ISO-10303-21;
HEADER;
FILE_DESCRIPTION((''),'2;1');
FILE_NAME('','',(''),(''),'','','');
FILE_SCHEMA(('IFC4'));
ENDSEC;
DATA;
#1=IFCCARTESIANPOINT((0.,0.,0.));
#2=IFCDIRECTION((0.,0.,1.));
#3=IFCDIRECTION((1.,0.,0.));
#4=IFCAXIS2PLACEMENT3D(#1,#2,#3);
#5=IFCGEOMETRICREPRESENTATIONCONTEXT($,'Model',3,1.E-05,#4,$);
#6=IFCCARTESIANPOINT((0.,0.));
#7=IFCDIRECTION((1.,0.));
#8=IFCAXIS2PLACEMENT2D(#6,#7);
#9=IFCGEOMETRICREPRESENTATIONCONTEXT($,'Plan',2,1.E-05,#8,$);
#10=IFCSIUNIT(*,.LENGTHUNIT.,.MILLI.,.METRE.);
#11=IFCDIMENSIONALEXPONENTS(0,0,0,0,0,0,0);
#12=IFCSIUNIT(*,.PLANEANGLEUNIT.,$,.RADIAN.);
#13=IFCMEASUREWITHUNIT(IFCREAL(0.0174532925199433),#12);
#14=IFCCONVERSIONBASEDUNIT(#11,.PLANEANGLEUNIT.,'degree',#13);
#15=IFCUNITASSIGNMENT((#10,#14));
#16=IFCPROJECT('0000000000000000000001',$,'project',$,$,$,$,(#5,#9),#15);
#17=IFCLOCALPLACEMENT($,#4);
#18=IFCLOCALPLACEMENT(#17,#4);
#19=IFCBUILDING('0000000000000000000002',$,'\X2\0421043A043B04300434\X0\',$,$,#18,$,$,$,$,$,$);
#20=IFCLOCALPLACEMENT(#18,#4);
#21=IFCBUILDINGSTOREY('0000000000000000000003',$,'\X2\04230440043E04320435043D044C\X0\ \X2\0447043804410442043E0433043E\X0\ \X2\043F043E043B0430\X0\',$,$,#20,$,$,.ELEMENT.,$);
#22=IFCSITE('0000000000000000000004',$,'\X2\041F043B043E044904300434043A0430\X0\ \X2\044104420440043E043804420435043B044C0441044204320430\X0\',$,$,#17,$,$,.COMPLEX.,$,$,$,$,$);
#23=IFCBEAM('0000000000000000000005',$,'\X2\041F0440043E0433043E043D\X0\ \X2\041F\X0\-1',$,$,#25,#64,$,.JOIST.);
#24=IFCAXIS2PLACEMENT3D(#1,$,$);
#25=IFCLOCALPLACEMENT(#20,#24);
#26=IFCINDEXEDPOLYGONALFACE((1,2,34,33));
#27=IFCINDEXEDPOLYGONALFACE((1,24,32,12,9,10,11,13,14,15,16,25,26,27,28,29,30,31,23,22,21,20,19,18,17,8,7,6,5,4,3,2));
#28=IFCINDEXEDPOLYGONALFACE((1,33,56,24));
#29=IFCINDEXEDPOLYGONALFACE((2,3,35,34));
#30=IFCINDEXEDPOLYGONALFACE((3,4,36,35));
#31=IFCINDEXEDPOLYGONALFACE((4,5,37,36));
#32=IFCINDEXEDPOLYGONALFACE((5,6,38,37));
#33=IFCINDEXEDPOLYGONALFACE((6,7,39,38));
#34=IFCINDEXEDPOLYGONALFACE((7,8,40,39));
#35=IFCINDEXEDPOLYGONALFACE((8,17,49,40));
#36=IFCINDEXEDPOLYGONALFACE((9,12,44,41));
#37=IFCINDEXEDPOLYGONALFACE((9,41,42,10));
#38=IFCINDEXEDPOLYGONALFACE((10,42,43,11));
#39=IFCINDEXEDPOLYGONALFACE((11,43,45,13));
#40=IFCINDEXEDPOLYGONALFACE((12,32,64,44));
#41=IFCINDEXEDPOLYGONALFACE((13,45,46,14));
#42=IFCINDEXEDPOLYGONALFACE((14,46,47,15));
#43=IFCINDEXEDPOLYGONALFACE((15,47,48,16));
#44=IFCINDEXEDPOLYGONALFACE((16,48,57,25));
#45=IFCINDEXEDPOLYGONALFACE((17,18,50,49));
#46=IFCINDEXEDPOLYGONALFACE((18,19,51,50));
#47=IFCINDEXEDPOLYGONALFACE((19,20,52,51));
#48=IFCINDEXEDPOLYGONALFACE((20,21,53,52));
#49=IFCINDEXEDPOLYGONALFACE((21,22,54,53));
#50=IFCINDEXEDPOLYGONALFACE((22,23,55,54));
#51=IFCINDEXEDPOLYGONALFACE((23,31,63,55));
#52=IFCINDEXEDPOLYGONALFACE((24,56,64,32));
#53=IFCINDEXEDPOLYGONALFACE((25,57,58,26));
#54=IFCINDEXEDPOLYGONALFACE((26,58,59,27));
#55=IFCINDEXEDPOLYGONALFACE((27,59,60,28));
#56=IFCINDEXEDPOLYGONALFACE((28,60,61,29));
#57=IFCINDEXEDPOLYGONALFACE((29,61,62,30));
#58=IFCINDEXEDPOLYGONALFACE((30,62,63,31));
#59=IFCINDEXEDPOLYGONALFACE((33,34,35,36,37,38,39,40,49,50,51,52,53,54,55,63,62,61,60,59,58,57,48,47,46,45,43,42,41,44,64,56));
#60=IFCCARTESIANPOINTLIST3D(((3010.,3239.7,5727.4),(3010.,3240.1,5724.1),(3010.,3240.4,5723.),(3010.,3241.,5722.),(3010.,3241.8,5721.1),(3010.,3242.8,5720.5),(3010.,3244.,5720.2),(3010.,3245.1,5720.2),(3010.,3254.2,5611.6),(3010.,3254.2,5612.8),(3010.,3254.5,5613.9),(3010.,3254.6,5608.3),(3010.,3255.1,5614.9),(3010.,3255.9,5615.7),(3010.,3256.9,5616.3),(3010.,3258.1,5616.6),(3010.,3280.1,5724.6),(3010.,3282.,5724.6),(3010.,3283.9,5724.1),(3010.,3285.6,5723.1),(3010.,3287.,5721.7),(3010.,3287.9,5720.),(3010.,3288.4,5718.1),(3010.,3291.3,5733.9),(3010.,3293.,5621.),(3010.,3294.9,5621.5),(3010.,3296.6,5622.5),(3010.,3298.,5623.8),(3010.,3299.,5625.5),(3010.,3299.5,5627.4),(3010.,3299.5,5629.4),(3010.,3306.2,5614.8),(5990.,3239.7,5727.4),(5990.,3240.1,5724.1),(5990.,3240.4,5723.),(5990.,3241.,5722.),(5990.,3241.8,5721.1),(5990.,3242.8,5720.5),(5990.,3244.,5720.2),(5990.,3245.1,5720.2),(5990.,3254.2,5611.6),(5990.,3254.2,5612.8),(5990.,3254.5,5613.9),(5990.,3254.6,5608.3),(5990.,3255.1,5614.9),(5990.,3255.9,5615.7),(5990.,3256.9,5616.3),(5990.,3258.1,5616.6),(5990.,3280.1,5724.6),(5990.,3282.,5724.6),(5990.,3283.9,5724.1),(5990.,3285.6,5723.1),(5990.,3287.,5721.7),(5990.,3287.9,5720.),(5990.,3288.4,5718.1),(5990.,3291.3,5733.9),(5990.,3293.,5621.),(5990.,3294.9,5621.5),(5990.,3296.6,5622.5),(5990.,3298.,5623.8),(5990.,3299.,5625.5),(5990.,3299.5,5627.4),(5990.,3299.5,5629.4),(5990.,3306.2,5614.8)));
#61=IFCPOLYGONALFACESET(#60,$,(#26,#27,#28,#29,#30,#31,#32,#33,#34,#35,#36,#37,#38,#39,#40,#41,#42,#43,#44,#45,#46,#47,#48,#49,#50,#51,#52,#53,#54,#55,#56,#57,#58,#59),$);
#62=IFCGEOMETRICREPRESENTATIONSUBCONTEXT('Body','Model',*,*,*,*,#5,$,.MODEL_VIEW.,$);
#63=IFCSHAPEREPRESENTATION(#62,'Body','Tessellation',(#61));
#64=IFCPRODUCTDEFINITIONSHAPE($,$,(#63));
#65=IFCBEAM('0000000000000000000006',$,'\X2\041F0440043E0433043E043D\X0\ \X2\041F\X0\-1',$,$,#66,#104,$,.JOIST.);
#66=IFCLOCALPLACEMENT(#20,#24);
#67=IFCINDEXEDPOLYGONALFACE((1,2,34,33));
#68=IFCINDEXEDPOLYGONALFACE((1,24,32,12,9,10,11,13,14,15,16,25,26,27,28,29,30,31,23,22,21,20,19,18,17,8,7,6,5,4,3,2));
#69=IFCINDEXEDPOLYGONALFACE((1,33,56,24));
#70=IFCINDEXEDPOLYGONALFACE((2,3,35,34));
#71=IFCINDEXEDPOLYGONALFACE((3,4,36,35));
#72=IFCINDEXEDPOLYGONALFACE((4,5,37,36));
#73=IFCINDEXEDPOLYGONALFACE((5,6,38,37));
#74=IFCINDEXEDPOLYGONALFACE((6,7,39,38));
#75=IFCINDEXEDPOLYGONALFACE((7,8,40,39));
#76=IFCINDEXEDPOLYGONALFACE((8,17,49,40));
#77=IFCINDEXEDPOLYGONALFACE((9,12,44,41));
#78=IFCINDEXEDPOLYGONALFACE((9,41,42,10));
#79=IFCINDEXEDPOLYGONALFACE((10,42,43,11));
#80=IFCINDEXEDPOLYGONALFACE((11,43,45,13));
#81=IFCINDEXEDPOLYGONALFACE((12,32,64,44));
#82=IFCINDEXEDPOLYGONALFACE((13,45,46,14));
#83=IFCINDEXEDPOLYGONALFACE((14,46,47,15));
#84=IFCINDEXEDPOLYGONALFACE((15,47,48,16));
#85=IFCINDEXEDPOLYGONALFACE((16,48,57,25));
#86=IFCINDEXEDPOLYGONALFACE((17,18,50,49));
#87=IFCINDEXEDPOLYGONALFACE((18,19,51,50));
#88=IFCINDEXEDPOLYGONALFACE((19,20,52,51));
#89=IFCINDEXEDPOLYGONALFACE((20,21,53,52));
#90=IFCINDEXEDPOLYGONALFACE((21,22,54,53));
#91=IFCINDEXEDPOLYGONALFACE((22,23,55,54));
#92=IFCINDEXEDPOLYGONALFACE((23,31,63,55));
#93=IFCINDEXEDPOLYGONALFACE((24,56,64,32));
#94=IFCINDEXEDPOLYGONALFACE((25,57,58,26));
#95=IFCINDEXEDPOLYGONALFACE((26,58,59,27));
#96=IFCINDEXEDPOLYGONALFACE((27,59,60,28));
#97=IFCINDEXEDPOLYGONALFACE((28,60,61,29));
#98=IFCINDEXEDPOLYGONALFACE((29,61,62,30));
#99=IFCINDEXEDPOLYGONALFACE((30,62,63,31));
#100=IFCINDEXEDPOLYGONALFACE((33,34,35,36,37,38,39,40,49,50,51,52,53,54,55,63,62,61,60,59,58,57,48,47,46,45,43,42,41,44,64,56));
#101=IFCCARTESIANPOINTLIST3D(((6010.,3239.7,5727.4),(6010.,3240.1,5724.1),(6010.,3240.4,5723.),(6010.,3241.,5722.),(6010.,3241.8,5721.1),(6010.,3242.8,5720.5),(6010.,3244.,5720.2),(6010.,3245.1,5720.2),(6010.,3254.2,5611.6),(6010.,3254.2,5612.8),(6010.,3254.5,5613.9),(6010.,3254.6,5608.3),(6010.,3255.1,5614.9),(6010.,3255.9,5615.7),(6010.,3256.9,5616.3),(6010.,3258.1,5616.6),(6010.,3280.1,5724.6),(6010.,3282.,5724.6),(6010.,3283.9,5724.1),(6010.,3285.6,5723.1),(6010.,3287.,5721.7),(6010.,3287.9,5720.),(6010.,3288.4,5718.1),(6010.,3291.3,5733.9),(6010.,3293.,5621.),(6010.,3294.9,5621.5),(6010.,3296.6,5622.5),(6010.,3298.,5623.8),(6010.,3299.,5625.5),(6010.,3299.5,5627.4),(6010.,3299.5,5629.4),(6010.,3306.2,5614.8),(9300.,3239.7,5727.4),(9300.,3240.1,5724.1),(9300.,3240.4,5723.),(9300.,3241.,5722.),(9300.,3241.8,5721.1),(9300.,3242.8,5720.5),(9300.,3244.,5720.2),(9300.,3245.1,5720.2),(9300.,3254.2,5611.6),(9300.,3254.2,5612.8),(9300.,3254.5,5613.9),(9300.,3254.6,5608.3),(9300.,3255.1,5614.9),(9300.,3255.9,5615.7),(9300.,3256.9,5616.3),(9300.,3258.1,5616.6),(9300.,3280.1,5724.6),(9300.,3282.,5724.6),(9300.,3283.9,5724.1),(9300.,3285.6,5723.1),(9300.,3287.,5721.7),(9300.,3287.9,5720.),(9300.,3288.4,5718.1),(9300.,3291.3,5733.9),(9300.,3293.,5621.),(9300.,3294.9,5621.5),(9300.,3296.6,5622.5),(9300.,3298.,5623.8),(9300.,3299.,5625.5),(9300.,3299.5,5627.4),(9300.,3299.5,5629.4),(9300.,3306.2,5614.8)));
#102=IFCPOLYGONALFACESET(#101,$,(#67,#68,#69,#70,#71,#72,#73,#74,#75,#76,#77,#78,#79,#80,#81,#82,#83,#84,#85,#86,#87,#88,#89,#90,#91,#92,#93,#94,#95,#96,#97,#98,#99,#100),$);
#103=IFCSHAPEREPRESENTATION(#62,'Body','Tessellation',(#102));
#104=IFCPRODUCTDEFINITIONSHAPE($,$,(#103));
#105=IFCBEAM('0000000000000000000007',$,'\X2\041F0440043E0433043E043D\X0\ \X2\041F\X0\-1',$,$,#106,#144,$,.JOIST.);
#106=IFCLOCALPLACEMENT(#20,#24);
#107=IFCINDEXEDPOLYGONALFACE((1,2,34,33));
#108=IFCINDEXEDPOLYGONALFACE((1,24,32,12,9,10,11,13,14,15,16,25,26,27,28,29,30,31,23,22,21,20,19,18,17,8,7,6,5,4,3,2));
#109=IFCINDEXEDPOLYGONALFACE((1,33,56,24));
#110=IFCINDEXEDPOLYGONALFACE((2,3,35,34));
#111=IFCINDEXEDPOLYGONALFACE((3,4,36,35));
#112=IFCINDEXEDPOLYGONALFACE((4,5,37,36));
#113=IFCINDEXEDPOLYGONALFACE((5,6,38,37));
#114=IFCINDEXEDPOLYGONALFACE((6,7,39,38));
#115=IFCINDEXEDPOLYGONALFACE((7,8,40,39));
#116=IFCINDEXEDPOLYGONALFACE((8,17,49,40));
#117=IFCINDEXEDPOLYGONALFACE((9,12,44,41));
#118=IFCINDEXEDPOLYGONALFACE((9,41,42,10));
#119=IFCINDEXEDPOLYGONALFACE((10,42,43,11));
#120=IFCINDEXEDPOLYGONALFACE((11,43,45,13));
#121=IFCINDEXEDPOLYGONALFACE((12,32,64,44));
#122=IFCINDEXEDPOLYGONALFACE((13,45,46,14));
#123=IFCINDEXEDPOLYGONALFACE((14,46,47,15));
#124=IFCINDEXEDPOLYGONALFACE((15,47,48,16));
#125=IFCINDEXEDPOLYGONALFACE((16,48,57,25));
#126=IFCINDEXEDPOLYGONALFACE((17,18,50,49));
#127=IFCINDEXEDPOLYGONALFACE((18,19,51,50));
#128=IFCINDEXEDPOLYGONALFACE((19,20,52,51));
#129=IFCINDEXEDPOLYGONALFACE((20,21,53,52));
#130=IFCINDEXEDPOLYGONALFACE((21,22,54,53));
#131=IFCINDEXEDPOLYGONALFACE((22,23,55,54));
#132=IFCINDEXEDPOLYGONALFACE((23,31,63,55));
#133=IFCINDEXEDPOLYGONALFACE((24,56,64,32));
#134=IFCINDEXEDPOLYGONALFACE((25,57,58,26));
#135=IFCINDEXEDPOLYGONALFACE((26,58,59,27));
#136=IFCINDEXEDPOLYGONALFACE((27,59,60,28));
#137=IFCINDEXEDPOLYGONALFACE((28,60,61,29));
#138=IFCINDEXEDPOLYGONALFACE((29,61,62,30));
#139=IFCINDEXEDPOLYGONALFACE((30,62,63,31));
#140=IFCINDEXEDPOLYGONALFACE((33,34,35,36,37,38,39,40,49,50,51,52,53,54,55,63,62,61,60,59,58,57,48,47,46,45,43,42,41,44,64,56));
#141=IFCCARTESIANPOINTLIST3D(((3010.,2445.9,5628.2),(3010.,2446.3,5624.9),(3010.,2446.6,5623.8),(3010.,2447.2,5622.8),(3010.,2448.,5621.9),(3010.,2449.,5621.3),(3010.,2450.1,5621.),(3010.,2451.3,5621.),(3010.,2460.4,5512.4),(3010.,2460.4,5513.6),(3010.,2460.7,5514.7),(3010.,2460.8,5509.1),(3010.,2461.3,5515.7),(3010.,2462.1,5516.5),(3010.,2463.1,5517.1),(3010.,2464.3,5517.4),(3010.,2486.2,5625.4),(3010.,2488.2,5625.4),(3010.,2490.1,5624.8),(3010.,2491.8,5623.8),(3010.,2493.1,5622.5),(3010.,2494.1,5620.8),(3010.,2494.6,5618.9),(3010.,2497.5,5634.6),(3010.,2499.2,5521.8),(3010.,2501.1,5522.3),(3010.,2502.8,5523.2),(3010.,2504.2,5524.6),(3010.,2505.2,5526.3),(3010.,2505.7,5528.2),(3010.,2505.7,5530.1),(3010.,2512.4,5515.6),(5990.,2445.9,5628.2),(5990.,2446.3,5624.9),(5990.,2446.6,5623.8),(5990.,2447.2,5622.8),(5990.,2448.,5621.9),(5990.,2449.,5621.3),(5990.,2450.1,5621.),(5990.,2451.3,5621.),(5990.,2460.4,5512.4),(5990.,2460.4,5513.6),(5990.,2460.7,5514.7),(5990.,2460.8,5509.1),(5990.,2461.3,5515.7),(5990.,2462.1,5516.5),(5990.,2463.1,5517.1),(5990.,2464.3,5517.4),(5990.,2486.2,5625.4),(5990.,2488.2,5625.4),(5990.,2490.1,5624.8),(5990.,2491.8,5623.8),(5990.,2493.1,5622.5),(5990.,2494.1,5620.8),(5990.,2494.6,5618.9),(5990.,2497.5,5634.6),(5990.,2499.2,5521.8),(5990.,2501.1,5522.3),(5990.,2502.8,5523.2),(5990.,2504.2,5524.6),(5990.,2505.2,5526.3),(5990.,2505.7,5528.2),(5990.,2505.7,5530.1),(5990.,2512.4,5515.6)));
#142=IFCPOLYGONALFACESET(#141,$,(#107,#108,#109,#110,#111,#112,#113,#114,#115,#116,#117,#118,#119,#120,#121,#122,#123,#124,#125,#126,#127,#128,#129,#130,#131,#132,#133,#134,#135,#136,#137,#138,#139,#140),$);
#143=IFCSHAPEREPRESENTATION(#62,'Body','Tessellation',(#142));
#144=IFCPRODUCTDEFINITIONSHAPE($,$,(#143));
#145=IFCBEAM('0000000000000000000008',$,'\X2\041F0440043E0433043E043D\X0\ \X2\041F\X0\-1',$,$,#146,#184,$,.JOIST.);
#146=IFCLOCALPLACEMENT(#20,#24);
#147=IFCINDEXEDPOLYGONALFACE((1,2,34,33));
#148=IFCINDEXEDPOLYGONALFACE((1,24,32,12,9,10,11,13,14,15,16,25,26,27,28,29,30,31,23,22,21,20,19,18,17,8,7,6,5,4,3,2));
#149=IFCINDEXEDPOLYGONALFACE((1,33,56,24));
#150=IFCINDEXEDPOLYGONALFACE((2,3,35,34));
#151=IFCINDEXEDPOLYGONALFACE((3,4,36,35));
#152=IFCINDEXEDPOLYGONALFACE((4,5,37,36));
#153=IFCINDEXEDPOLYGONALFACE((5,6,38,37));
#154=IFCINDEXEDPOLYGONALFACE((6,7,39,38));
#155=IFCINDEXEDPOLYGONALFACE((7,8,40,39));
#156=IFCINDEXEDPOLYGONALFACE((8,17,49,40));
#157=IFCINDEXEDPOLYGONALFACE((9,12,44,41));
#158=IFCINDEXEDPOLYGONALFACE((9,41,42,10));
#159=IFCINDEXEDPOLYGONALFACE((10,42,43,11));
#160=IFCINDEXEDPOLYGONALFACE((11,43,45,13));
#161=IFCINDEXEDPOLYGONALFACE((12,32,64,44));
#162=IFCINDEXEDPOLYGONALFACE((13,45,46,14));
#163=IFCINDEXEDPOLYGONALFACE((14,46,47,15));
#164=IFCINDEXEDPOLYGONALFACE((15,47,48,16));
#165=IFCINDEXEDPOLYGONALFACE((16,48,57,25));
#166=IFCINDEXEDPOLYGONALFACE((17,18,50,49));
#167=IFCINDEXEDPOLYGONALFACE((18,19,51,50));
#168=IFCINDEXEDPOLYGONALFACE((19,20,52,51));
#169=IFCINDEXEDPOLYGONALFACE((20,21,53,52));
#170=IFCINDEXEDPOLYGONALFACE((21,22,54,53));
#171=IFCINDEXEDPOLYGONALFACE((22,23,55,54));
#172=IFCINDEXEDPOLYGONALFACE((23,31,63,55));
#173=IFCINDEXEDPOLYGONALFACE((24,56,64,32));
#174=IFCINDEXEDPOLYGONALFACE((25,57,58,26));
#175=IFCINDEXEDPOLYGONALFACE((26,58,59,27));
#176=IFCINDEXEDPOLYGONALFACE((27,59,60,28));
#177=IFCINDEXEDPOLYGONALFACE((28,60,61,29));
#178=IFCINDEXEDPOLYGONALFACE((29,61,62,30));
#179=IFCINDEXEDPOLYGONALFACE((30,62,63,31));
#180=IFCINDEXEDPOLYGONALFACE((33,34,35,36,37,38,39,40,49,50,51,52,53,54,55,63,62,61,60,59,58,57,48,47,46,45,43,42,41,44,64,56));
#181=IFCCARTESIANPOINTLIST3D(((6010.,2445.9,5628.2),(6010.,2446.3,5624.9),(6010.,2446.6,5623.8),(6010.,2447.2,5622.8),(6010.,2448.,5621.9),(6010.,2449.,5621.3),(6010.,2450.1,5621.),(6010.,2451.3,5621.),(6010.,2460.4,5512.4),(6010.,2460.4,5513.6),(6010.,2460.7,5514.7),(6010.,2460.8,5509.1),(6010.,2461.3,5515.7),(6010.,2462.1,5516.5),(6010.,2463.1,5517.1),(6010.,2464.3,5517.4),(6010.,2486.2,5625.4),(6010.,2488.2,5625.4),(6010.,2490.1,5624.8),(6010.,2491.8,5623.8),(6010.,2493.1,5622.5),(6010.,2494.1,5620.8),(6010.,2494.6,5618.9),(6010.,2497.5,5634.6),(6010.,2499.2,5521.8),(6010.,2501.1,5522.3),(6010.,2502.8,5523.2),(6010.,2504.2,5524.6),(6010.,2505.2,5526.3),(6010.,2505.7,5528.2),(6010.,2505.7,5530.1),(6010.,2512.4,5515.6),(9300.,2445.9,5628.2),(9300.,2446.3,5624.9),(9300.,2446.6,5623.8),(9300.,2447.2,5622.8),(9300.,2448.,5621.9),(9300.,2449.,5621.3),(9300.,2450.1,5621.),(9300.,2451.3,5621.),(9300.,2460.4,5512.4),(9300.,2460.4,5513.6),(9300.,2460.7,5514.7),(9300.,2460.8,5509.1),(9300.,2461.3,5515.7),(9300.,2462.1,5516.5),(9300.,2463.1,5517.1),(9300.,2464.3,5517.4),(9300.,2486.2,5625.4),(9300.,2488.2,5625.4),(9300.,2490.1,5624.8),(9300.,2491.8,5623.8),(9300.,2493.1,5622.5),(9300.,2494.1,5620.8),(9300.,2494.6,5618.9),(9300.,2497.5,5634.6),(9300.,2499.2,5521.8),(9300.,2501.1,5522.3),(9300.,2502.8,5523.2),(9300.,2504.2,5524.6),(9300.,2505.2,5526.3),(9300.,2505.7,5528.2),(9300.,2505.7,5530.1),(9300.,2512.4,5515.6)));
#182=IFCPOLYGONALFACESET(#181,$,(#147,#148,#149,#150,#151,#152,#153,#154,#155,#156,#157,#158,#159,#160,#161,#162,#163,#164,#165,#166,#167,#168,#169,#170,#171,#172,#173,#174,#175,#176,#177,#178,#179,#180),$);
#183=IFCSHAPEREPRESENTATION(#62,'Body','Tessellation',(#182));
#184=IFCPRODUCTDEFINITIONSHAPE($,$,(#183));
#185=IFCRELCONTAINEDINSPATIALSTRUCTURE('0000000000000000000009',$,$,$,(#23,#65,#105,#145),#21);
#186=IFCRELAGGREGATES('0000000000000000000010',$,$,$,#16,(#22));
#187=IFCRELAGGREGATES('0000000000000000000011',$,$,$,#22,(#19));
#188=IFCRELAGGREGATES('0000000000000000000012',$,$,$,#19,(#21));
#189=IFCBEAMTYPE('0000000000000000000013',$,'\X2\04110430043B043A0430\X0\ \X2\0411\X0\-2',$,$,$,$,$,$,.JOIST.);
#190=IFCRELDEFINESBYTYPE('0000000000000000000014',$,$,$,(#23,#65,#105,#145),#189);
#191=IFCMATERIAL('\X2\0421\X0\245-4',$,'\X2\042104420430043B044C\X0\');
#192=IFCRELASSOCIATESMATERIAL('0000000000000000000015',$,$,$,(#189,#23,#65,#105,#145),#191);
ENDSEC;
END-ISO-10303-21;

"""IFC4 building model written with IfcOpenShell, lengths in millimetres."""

from ifc_helpers import new_model, entity, si_unit, converted_unit, frame, origin_with_axes, origin_2d_with_axis, place, context, subcontext, project, spatial, u_section, extrude, material, material_profile, profile_set, profile_usage, type_object, element, save


model = new_model("IFC4")

# Units and contexts
model_context = context("Model", 3, precision=1e-05, world=origin_with_axes())
plan_context = context("Plan", 2, precision=1e-05, world=origin_2d_with_axis())
body_context = subcontext(model_context, "Body", "Model", "MODEL_VIEW")
ifc_project = project(units=[si_unit("LENGTHUNIT", "METRE", prefix="MILLI"), converted_unit("PLANEANGLEUNIT", "degree", entity("IfcReal", 0.0174532925199433), si_unit("PLANEANGLEUNIT", "RADIAN"), dimensions=[0, 0, 0, 0, 0, 0, 0])], contexts=[model_context, plan_context])

# Site, building, storey
site_placement = place(None, origin_with_axes())
site = spatial("IfcSite", under=ifc_project, at=site_placement, Name="Площадка строительства", CompositionType="COMPLEX")
building_placement = place(site_placement, origin_with_axes())
building = spatial("IfcBuilding", under=site, at=building_placement, Name="Склад")
storey_placement = place(building_placement, origin_with_axes())
storey = spatial("IfcBuildingStorey", under=building, at=storey_placement, Name="Уровень чистого пола", CompositionType="ELEMENT")

# Beams
ifc_material_1 = material(Name="С245-4", Category="Сталь")
ifc_material_profile_1 = material_profile(ifc_material_1, u_section(Depth=120.0, FlangeWidth=52.0, WebThickness=4.8, FlangeThickness=7.8, FilletRadius=7.5, EdgeRadius=4.5, FlangeSlope=0.0))
ifc_profile_set_1 = profile_set([ifc_material_profile_1], Name="U12P_S245-4")
ifc_profile_usage_1 = profile_usage(ifc_profile_set_1, cardinal=3)
beam_type_1 = type_object("IfcBeamType", Name="Балка Б-2", PredefinedType="JOIST", material=ifc_profile_set_1)
beam_1_placement = place(storey_placement, frame((5990.0, 3306.2, 5614.8), z_axis=(-1.0, 0.0, 0.0), x_axis=(0.0, -0.99228, -0.12402)))
element("IfcBeam", 1, at=beam_1_placement, inside=storey, type_object=beam_type_1, material=ifc_profile_usage_1, Name="Прогон П-1", PredefinedType="JOIST", context=body_context, shape_type="SweptSolid", body=[
    extrude(u_section(Depth=120.0, FlangeWidth=52.0, WebThickness=4.8, FlangeThickness=7.8, FilletRadius=7.5, EdgeRadius=4.5, FlangeSlope=0.0), frame((26.0, 60.0, 0.0), z_axis=(0.0, 0.0, 1.0), x_axis=(1.0, 0.0, 0.0)), (0.0, 0.0, 1.0), 2980.0),
])
beam_2_placement = place(storey_placement, frame((9300.0, 3306.2, 5614.8), z_axis=(-1.0, 0.0, 0.0), x_axis=(0.0, -0.99228, -0.12402)))
element("IfcBeam", 2, at=beam_2_placement, inside=storey, type_object=beam_type_1, material=ifc_profile_usage_1, Name="Прогон П-1", PredefinedType="JOIST", context=body_context, shape_type="SweptSolid", body=[
    extrude(u_section(Depth=120.0, FlangeWidth=52.0, WebThickness=4.8, FlangeThickness=7.8, FilletRadius=7.5, EdgeRadius=4.5, FlangeSlope=0.0), frame((26.0, 60.0, 0.0), z_axis=(0.0, 0.0, 1.0), x_axis=(1.0, 0.0, 0.0)), (0.0, 0.0, 1.0), 3290.0),
])
beam_3_placement = place(storey_placement, frame((5990.0, 2512.4, 5515.6), z_axis=(-1.0, 0.0, 0.0), x_axis=(0.0, -0.99228, -0.12402)))
element("IfcBeam", 3, at=beam_3_placement, inside=storey, type_object=beam_type_1, material=ifc_profile_usage_1, Name="Прогон П-1", PredefinedType="JOIST", context=body_context, shape_type="SweptSolid", body=[
    extrude(u_section(Depth=120.0, FlangeWidth=52.0, WebThickness=4.8, FlangeThickness=7.8, FilletRadius=7.5, EdgeRadius=4.5, FlangeSlope=0.0), frame((26.0, 60.0, 0.0), z_axis=(0.0, 0.0, 1.0), x_axis=(1.0, 0.0, 0.0)), (0.0, 0.0, 1.0), 2980.0),
])
beam_4_placement = place(storey_placement, frame((9300.0, 2512.4, 5515.6), z_axis=(-1.0, 0.0, 0.0), x_axis=(0.0, -0.99228, -0.12402)))
element("IfcBeam", 4, at=beam_4_placement, inside=storey, type_object=beam_type_1, material=ifc_profile_usage_1, Name="Прогон П-1", PredefinedType="JOIST", context=body_context, shape_type="SweptSolid", body=[
    extrude(u_section(Depth=120.0, FlangeWidth=52.0, WebThickness=4.8, FlangeThickness=7.8, FilletRadius=7.5, EdgeRadius=4.5, FlangeSlope=0.0), frame((26.0, 60.0, 0.0), z_axis=(0.0, 0.0, 1.0), x_axis=(1.0, 0.0, 0.0)), (0.0, 0.0, 1.0), 3290.0),
])

save(model, "model.ifc")
